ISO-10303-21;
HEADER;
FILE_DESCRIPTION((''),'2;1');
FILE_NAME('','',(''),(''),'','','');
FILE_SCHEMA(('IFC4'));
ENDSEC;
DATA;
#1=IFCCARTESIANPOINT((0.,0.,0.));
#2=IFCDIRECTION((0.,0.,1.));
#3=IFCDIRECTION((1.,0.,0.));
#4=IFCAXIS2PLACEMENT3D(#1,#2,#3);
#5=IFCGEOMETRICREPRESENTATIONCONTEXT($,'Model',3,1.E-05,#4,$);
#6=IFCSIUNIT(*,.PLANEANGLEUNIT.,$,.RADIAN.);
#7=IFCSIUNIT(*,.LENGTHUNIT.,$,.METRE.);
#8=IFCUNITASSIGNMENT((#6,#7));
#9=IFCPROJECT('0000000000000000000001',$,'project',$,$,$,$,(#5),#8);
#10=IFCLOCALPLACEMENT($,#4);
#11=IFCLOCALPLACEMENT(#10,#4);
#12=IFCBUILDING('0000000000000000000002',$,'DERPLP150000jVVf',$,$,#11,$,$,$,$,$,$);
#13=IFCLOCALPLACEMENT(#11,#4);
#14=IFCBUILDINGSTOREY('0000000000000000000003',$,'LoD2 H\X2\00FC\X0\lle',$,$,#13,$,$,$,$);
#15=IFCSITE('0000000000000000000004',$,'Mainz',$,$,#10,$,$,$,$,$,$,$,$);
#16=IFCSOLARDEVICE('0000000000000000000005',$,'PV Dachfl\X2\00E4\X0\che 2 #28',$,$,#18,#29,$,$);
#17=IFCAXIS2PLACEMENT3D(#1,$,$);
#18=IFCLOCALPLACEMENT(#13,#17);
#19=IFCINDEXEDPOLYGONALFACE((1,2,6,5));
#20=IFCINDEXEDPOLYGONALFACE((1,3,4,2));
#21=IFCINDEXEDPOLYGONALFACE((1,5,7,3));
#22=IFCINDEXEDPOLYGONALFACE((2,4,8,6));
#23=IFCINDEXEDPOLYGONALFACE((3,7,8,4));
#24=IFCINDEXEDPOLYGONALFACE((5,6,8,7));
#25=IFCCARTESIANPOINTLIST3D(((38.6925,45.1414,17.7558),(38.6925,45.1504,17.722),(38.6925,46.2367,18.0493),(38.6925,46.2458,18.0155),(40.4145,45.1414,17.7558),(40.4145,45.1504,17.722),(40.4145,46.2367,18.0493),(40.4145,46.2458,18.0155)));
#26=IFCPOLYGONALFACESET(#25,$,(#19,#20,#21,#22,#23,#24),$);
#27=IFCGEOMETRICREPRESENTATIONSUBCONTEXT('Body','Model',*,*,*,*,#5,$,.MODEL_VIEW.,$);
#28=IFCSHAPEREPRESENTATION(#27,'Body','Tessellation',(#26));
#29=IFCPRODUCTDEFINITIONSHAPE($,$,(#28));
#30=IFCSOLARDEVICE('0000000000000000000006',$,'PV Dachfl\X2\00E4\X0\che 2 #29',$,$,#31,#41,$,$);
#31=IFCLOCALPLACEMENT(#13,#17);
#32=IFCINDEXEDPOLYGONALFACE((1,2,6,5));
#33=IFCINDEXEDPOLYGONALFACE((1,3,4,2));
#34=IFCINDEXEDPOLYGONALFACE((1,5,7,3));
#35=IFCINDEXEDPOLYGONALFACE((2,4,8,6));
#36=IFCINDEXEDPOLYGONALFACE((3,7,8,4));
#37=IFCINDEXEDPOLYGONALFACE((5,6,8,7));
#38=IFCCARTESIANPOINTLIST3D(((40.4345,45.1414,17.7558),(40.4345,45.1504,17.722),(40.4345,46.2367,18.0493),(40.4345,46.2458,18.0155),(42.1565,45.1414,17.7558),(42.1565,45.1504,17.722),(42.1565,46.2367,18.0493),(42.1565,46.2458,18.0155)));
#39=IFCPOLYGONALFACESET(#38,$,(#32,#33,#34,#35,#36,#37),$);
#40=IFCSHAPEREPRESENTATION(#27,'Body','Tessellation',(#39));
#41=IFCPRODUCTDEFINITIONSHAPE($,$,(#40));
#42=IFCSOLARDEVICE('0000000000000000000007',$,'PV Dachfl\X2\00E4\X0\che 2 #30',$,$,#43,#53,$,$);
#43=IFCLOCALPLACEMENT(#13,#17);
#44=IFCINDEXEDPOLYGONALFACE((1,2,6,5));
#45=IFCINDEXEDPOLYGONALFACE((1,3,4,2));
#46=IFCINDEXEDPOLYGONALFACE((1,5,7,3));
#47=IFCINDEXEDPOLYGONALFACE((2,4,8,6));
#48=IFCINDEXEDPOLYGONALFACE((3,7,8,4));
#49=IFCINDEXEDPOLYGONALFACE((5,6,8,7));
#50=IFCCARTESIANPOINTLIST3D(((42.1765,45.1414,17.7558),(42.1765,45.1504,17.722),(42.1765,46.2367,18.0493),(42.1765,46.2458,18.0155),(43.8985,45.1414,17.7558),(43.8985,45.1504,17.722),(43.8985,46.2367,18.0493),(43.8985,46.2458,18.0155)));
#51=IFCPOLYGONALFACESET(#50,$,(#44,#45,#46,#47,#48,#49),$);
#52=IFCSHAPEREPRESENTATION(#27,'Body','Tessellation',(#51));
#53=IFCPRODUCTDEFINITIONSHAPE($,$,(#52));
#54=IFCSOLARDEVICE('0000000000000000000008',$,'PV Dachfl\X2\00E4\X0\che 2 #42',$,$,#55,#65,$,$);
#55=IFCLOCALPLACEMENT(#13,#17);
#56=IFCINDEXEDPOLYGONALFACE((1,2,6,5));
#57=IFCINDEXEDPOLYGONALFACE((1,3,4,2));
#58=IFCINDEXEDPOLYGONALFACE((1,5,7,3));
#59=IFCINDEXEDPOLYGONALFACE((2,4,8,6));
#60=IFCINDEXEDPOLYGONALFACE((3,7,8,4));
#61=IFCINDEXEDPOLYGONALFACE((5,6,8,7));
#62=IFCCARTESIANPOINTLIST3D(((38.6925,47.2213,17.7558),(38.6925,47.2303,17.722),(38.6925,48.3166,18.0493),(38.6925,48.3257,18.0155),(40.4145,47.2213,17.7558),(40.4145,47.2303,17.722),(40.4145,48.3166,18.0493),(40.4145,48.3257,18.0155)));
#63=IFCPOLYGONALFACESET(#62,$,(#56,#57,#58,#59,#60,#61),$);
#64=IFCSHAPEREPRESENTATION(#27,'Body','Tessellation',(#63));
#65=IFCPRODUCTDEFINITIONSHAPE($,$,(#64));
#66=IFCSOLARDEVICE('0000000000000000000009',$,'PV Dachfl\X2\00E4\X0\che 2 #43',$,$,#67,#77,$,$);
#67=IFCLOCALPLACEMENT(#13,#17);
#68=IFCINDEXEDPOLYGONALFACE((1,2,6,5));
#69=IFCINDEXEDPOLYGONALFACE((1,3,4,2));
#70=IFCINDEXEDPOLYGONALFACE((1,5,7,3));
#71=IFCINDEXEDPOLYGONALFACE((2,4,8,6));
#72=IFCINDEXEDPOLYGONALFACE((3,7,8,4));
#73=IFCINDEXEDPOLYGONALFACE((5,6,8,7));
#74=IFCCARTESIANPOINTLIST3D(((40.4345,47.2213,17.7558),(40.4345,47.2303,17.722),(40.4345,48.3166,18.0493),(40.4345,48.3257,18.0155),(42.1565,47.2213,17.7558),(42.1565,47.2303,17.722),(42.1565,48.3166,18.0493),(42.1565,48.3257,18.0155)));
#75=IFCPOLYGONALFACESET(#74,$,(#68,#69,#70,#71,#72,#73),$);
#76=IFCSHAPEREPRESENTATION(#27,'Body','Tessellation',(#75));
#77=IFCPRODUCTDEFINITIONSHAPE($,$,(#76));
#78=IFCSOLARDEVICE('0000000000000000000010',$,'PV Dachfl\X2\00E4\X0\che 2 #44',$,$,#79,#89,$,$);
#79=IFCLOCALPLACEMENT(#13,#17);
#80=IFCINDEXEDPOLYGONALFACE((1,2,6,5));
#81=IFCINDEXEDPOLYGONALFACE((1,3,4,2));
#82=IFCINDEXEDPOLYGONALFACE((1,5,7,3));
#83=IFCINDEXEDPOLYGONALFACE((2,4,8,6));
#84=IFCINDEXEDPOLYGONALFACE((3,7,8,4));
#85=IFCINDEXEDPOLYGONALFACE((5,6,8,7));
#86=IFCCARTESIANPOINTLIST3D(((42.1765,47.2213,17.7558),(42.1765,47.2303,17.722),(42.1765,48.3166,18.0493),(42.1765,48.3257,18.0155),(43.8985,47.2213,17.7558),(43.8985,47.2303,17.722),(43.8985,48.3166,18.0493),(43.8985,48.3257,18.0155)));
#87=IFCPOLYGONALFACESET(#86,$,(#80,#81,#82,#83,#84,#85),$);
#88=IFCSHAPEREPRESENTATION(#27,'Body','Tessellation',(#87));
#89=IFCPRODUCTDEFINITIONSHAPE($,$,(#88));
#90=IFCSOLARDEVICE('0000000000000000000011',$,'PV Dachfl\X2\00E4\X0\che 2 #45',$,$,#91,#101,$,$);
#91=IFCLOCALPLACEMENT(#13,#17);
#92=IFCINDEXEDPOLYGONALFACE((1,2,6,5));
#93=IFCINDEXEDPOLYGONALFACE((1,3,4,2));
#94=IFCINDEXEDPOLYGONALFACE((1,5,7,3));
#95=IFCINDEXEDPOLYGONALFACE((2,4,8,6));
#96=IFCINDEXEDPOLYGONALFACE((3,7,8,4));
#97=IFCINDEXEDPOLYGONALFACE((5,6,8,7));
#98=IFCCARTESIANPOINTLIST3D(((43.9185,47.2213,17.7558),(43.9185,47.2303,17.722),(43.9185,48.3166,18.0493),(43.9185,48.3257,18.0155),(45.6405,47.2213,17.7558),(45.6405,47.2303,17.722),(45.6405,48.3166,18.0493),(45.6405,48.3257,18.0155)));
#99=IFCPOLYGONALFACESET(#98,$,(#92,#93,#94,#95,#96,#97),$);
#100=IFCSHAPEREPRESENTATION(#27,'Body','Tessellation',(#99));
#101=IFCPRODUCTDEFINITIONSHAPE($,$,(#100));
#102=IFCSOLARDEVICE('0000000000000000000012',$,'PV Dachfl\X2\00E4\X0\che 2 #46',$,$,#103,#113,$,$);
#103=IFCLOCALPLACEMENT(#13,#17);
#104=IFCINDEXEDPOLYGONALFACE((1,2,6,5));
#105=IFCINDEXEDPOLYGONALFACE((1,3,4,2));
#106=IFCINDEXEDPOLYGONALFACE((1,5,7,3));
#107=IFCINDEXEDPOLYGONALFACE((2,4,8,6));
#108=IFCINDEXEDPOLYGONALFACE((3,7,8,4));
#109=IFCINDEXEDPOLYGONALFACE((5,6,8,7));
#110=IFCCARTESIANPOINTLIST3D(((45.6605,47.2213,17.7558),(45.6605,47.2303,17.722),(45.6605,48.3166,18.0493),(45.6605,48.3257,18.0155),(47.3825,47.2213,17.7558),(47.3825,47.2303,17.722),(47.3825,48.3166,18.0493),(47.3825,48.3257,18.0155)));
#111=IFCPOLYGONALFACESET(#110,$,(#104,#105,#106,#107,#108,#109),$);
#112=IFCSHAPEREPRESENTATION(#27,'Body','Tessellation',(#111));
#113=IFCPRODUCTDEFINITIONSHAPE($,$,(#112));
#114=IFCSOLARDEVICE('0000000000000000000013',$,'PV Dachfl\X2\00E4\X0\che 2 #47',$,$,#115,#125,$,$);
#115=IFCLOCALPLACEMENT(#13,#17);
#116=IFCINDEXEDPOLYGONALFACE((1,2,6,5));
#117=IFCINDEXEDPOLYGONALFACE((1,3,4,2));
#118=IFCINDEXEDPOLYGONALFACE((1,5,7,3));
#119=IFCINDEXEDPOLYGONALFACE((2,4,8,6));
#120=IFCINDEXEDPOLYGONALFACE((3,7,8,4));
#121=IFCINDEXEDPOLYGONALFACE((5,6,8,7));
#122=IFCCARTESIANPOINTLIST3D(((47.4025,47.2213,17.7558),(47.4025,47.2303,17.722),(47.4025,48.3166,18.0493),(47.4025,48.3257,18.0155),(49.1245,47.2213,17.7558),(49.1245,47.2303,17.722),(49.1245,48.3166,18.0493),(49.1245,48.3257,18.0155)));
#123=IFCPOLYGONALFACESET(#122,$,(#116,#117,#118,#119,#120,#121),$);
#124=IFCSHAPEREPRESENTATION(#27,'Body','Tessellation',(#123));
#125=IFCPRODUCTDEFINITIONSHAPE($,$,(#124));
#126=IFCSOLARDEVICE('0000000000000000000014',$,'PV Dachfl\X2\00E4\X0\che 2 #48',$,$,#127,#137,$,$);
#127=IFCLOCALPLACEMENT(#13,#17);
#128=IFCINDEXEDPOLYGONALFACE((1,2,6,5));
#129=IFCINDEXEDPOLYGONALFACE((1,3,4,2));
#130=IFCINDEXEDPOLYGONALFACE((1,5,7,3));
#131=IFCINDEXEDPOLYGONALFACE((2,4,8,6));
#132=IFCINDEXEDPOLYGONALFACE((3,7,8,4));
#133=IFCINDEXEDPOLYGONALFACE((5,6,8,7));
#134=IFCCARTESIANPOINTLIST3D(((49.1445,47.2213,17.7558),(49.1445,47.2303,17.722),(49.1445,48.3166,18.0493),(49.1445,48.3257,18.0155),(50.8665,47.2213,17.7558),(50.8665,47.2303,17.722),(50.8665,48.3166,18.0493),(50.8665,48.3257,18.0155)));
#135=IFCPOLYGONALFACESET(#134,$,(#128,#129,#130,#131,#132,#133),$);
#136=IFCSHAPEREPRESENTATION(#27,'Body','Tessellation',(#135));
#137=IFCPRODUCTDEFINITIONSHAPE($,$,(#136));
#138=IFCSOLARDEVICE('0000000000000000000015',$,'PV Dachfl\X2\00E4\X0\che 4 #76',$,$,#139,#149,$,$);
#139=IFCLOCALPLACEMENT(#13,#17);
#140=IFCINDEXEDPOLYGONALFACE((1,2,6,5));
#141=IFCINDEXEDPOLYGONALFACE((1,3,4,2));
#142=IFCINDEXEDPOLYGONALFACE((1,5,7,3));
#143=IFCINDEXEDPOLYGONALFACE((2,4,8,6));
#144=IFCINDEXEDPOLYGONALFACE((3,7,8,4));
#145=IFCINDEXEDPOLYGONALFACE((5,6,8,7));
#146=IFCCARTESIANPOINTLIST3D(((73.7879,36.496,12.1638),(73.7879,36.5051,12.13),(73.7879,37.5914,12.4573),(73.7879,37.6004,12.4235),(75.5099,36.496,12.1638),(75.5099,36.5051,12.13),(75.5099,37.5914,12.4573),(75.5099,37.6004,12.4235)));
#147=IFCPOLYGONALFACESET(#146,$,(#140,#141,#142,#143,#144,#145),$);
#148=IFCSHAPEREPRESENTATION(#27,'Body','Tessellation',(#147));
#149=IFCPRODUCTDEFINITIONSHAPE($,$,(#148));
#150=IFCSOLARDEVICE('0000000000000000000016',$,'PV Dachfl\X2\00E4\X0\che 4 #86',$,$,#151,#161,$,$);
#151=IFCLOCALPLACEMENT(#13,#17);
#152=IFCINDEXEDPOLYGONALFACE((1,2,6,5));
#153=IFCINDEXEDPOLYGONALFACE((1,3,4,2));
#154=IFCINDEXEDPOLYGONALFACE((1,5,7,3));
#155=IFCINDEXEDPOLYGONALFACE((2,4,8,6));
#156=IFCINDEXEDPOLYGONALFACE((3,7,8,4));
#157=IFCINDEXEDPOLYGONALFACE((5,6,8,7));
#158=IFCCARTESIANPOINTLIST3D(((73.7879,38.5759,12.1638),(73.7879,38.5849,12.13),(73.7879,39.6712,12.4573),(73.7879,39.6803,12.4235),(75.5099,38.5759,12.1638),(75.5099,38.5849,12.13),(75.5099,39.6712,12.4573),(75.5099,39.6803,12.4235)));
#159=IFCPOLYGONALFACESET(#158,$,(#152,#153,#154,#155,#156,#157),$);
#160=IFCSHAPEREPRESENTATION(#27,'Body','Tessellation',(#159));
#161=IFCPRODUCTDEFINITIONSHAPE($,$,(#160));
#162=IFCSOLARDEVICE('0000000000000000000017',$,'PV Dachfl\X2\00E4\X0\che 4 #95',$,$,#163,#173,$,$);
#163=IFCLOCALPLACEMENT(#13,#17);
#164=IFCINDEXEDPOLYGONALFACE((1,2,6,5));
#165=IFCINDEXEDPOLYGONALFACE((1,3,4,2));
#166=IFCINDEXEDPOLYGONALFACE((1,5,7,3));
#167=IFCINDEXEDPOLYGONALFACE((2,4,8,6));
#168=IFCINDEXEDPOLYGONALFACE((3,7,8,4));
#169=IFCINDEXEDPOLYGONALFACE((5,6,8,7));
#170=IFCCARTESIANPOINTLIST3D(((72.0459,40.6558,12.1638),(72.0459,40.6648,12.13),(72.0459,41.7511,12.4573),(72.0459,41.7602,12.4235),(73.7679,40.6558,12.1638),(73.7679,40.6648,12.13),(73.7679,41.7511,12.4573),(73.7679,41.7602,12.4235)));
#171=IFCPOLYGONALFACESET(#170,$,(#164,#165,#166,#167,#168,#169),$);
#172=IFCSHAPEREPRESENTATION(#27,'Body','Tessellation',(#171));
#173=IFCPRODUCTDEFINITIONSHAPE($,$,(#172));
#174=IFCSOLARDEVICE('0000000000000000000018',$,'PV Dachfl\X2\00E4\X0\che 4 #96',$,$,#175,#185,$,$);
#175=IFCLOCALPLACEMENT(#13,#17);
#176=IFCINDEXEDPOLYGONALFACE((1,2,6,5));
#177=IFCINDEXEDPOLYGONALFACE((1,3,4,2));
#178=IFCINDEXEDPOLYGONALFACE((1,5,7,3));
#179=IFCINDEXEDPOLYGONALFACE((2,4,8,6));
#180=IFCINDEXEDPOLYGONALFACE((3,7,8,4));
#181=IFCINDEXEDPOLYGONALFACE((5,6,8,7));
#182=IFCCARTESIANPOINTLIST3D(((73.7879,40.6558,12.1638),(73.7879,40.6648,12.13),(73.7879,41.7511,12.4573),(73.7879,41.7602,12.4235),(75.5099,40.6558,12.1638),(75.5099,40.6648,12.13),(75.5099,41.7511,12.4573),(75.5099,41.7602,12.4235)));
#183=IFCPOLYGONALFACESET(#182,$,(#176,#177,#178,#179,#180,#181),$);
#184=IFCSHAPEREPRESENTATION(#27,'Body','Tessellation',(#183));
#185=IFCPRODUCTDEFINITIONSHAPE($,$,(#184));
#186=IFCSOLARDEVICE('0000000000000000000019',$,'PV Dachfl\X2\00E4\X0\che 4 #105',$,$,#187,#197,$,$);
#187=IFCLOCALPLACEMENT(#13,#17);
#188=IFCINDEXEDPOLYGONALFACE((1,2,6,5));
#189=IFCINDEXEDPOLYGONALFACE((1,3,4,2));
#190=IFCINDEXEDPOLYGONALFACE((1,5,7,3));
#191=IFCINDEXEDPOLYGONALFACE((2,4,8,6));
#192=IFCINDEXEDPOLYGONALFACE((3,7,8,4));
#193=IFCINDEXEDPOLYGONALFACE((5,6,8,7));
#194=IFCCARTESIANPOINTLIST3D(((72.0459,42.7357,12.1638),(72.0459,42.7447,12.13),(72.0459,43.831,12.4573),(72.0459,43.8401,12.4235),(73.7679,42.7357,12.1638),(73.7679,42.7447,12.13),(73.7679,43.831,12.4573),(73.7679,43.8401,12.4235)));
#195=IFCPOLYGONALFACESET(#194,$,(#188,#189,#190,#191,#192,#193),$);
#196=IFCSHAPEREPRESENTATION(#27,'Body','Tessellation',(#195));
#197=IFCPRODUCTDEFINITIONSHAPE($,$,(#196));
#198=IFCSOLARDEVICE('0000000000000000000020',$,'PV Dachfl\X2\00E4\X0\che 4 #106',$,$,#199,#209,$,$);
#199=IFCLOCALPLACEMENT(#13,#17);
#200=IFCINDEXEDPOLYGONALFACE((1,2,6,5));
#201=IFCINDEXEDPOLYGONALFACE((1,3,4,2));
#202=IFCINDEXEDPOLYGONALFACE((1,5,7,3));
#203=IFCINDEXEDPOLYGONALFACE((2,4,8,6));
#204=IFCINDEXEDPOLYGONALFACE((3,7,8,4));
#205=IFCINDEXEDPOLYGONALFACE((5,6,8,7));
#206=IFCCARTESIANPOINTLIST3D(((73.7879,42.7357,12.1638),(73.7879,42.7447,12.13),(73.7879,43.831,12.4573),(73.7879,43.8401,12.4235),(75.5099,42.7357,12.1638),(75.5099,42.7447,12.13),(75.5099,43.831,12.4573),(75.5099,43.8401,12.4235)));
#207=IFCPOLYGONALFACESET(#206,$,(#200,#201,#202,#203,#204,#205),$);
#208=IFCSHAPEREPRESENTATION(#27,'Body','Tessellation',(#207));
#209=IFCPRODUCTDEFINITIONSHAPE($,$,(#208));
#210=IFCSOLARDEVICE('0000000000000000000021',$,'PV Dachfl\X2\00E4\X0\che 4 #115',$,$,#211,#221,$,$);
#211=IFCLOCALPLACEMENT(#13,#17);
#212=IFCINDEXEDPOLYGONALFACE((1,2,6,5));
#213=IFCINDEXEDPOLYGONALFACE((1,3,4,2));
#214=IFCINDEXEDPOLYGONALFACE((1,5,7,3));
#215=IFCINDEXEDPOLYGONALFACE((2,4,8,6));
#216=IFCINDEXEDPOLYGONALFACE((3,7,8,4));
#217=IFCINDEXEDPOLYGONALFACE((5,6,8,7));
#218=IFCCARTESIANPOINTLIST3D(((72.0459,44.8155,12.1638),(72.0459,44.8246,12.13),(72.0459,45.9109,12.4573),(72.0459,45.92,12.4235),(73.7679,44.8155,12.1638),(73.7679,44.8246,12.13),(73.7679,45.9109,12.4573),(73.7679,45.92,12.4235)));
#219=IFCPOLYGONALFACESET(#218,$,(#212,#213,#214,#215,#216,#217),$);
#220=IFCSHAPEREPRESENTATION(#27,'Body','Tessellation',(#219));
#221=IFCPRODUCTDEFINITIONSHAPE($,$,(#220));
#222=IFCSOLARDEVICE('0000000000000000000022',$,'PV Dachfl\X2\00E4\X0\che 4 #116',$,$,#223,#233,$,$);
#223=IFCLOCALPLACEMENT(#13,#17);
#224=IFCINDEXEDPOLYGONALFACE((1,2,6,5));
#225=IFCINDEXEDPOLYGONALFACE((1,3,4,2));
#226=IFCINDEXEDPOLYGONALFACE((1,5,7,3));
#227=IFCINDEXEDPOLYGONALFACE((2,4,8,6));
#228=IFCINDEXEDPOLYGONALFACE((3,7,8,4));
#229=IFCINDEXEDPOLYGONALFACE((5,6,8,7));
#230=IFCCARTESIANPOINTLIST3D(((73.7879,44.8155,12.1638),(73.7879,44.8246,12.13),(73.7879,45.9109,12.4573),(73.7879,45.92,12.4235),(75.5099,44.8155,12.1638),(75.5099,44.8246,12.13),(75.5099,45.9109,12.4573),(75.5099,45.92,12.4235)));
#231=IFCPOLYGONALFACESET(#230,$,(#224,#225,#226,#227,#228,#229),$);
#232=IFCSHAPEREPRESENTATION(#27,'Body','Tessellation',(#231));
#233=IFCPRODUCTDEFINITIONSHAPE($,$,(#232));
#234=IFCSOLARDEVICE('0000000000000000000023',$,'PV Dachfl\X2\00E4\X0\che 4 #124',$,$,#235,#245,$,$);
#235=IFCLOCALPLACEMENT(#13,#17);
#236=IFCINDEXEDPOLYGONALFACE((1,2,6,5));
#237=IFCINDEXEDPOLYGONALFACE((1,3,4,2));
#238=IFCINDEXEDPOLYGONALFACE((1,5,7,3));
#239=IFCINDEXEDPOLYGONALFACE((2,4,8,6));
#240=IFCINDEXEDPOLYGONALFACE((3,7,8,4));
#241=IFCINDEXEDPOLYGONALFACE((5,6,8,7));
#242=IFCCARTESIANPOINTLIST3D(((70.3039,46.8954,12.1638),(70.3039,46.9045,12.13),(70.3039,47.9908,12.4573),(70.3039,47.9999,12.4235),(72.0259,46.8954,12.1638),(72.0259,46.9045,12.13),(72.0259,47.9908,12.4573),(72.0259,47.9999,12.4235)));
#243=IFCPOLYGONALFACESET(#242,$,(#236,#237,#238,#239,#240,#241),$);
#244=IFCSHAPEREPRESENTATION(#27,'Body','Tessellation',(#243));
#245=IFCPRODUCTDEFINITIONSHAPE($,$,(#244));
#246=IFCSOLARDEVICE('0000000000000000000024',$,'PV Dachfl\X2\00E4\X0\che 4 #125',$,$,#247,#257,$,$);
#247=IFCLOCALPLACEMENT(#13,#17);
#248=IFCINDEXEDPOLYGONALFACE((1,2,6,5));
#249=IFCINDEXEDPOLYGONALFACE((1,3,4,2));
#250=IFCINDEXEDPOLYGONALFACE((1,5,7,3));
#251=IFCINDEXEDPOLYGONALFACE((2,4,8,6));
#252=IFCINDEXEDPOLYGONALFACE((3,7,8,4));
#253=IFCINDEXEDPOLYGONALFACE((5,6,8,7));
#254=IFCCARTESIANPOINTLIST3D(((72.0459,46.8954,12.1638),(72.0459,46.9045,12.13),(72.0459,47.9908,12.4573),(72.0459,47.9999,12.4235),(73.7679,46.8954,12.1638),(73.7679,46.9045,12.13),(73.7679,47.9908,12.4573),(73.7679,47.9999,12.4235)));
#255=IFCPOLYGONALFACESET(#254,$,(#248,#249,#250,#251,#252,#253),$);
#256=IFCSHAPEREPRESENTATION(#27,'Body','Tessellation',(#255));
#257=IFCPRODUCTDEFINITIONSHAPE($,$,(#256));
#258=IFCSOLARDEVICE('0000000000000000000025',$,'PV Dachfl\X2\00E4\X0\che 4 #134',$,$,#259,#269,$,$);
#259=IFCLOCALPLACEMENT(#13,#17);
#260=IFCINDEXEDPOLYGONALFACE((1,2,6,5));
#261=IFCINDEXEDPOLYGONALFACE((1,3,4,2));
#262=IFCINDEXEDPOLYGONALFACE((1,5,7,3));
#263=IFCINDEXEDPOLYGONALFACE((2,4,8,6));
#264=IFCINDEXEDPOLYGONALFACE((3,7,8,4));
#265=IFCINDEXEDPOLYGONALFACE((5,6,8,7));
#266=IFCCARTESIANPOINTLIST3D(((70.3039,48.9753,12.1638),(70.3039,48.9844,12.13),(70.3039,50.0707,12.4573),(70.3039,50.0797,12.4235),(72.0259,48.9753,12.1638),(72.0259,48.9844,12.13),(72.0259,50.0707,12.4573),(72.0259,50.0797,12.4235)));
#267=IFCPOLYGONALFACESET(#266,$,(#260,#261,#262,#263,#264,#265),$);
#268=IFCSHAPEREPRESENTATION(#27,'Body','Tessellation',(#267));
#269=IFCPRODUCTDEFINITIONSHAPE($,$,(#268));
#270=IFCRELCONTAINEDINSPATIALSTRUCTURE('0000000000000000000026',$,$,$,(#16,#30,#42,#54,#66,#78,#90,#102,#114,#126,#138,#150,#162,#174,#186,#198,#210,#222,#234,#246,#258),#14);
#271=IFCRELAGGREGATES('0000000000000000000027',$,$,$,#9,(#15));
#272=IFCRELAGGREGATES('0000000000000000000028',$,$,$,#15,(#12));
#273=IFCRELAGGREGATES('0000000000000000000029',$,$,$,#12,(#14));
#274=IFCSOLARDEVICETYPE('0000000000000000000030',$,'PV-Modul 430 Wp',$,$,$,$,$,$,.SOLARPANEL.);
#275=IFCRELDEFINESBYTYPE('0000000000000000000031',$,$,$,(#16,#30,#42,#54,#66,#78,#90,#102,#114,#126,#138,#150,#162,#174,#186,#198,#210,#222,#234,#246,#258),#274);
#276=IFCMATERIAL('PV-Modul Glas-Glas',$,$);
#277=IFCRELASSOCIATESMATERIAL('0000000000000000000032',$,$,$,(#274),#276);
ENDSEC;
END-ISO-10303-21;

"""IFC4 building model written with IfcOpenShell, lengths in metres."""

from ifc_helpers import new_model, si_unit, frame, frame_2d, origin, origin_with_axes, place, context, subcontext, project, spatial, rectangle, extrude, source, transform, mapped, material, type_object, type_shapes, element, save


model = new_model("IFC4")

# Units and contexts
model_context = context("Model", 3, precision=1e-05, world=origin_with_axes())
body_context = subcontext(model_context, "Body", "Model", "MODEL_VIEW")
ifc_project = project(units=[si_unit("PLANEANGLEUNIT", "RADIAN"), si_unit("LENGTHUNIT", "METRE")], contexts=[model_context])

# Site, building, storey
site_placement = place(None, origin_with_axes())
site = spatial("IfcSite", under=ifc_project, at=site_placement, Name="Mainz")
building_placement = place(site_placement, origin_with_axes())
building = spatial("IfcBuilding", under=site, at=building_placement, Name="DERPLP150000jVVf")
storey_placement = place(building_placement, origin_with_axes())
storey = spatial("IfcBuildingStorey", under=building, at=storey_placement, Name="LoD2 Hülle")

# Solar devices
ifc_material = material(Name="PV-Modul Glas-Glas")
solar_device_type = type_object("IfcSolarDeviceType", Name="PV-Modul 430 Wp", PredefinedType="SOLARPANEL", material=ifc_material)
shared_shape = source(origin_with_axes(), body_context, "Body", "SweptSolid", [
    extrude(rectangle(XDim=1.722, YDim=1.134, at=frame_2d((0.861, 0.567))), origin(), (0.0, 0.0, 1.0), 0.035),
])
type_shapes(solar_device_type, [shared_shape])
for number, where, z_axis, x_axis, name in (
    (1, (38.6925, 45.1504, 17.722), (0.0, -0.258819, 0.965926), (1.0, 0.0, 0.0), "PV Dachfläche 2 #28"),
    (2, (40.4345, 45.1504, 17.722), (0.0, -0.258819, 0.965926), (1.0, 0.0, 0.0), "PV Dachfläche 2 #29"),
    (3, (42.1765, 45.1504, 17.722), (0.0, -0.258819, 0.965926), (1.0, 0.0, 0.0), "PV Dachfläche 2 #30"),
    (4, (38.6925, 47.2303, 17.722), (0.0, -0.258819, 0.965926), (1.0, 0.0, 0.0), "PV Dachfläche 2 #42"),
    (5, (40.4345, 47.2303, 17.722), (0.0, -0.258819, 0.965926), (1.0, 0.0, 0.0), "PV Dachfläche 2 #43"),
    (6, (42.1765, 47.2303, 17.722), (0.0, -0.258819, 0.965926), (1.0, 0.0, 0.0), "PV Dachfläche 2 #44"),
    (7, (43.9185, 47.2303, 17.722), (0.0, -0.258819, 0.965926), (1.0, 0.0, 0.0), "PV Dachfläche 2 #45"),
    (8, (45.6605, 47.2303, 17.722), (0.0, -0.258819, 0.965926), (1.0, 0.0, 0.0), "PV Dachfläche 2 #46"),
    (9, (47.4025, 47.2303, 17.722), (0.0, -0.258819, 0.965926), (1.0, 0.0, 0.0), "PV Dachfläche 2 #47"),
    (10, (49.1445, 47.2303, 17.722), (0.0, -0.258819, 0.965926), (1.0, 0.0, 0.0), "PV Dachfläche 2 #48"),
    (11, (73.7879, 36.5051, 12.13), (0.0, -0.258819, 0.965926), (1.0, 0.0, 0.0), "PV Dachfläche 4 #76"),
    (12, (73.7879, 38.5849, 12.13), (0.0, -0.258819, 0.965926), (1.0, 0.0, 0.0), "PV Dachfläche 4 #86"),
    (13, (72.0459, 40.6648, 12.13), (0.0, -0.258819, 0.965926), (1.0, 0.0, 0.0), "PV Dachfläche 4 #95"),
    (14, (73.7879, 40.6648, 12.13), (0.0, -0.258819, 0.965926), (1.0, 0.0, 0.0), "PV Dachfläche 4 #96"),
    (15, (72.0459, 42.7447, 12.13), (0.0, -0.258819, 0.965926), (1.0, 0.0, 0.0), "PV Dachfläche 4 #105"),
    (16, (73.7879, 42.7447, 12.13), (0.0, -0.258819, 0.965926), (1.0, 0.0, 0.0), "PV Dachfläche 4 #106"),
    (17, (72.0459, 44.8246, 12.13), (0.0, -0.258819, 0.965926), (1.0, 0.0, 0.0), "PV Dachfläche 4 #115"),
    (18, (73.7879, 44.8246, 12.13), (0.0, -0.258819, 0.965926), (1.0, 0.0, 0.0), "PV Dachfläche 4 #116"),
    (19, (70.3039, 46.9045, 12.13), (0.0, -0.258819, 0.965926), (1.0, 0.0, 0.0), "PV Dachfläche 4 #124"),
    (20, (72.0459, 46.9045, 12.13), (0.0, -0.258819, 0.965926), (1.0, 0.0, 0.0), "PV Dachfläche 4 #125"),
    (21, (70.3039, 48.9844, 12.13), (0.0, -0.258819, 0.965926), (1.0, 0.0, 0.0), "PV Dachfläche 4 #134"),
):
    element("IfcSolarDevice", number, at=place(storey_placement, frame(where, z_axis=z_axis, x_axis=x_axis)), inside=storey, type_object=solar_device_type, Name=name, context=body_context, shape_type="MappedRepresentation", body=[
        mapped(shared_shape, transform((0.0, 0.0, 0.0), x_axis=(1.0, 0.0, 0.0), y_axis=(0.0, 1.0, 0.0), z_axis=(0.0, 0.0, 1.0), scale=1.0)),
    ])

save(model, "model.ifc")
